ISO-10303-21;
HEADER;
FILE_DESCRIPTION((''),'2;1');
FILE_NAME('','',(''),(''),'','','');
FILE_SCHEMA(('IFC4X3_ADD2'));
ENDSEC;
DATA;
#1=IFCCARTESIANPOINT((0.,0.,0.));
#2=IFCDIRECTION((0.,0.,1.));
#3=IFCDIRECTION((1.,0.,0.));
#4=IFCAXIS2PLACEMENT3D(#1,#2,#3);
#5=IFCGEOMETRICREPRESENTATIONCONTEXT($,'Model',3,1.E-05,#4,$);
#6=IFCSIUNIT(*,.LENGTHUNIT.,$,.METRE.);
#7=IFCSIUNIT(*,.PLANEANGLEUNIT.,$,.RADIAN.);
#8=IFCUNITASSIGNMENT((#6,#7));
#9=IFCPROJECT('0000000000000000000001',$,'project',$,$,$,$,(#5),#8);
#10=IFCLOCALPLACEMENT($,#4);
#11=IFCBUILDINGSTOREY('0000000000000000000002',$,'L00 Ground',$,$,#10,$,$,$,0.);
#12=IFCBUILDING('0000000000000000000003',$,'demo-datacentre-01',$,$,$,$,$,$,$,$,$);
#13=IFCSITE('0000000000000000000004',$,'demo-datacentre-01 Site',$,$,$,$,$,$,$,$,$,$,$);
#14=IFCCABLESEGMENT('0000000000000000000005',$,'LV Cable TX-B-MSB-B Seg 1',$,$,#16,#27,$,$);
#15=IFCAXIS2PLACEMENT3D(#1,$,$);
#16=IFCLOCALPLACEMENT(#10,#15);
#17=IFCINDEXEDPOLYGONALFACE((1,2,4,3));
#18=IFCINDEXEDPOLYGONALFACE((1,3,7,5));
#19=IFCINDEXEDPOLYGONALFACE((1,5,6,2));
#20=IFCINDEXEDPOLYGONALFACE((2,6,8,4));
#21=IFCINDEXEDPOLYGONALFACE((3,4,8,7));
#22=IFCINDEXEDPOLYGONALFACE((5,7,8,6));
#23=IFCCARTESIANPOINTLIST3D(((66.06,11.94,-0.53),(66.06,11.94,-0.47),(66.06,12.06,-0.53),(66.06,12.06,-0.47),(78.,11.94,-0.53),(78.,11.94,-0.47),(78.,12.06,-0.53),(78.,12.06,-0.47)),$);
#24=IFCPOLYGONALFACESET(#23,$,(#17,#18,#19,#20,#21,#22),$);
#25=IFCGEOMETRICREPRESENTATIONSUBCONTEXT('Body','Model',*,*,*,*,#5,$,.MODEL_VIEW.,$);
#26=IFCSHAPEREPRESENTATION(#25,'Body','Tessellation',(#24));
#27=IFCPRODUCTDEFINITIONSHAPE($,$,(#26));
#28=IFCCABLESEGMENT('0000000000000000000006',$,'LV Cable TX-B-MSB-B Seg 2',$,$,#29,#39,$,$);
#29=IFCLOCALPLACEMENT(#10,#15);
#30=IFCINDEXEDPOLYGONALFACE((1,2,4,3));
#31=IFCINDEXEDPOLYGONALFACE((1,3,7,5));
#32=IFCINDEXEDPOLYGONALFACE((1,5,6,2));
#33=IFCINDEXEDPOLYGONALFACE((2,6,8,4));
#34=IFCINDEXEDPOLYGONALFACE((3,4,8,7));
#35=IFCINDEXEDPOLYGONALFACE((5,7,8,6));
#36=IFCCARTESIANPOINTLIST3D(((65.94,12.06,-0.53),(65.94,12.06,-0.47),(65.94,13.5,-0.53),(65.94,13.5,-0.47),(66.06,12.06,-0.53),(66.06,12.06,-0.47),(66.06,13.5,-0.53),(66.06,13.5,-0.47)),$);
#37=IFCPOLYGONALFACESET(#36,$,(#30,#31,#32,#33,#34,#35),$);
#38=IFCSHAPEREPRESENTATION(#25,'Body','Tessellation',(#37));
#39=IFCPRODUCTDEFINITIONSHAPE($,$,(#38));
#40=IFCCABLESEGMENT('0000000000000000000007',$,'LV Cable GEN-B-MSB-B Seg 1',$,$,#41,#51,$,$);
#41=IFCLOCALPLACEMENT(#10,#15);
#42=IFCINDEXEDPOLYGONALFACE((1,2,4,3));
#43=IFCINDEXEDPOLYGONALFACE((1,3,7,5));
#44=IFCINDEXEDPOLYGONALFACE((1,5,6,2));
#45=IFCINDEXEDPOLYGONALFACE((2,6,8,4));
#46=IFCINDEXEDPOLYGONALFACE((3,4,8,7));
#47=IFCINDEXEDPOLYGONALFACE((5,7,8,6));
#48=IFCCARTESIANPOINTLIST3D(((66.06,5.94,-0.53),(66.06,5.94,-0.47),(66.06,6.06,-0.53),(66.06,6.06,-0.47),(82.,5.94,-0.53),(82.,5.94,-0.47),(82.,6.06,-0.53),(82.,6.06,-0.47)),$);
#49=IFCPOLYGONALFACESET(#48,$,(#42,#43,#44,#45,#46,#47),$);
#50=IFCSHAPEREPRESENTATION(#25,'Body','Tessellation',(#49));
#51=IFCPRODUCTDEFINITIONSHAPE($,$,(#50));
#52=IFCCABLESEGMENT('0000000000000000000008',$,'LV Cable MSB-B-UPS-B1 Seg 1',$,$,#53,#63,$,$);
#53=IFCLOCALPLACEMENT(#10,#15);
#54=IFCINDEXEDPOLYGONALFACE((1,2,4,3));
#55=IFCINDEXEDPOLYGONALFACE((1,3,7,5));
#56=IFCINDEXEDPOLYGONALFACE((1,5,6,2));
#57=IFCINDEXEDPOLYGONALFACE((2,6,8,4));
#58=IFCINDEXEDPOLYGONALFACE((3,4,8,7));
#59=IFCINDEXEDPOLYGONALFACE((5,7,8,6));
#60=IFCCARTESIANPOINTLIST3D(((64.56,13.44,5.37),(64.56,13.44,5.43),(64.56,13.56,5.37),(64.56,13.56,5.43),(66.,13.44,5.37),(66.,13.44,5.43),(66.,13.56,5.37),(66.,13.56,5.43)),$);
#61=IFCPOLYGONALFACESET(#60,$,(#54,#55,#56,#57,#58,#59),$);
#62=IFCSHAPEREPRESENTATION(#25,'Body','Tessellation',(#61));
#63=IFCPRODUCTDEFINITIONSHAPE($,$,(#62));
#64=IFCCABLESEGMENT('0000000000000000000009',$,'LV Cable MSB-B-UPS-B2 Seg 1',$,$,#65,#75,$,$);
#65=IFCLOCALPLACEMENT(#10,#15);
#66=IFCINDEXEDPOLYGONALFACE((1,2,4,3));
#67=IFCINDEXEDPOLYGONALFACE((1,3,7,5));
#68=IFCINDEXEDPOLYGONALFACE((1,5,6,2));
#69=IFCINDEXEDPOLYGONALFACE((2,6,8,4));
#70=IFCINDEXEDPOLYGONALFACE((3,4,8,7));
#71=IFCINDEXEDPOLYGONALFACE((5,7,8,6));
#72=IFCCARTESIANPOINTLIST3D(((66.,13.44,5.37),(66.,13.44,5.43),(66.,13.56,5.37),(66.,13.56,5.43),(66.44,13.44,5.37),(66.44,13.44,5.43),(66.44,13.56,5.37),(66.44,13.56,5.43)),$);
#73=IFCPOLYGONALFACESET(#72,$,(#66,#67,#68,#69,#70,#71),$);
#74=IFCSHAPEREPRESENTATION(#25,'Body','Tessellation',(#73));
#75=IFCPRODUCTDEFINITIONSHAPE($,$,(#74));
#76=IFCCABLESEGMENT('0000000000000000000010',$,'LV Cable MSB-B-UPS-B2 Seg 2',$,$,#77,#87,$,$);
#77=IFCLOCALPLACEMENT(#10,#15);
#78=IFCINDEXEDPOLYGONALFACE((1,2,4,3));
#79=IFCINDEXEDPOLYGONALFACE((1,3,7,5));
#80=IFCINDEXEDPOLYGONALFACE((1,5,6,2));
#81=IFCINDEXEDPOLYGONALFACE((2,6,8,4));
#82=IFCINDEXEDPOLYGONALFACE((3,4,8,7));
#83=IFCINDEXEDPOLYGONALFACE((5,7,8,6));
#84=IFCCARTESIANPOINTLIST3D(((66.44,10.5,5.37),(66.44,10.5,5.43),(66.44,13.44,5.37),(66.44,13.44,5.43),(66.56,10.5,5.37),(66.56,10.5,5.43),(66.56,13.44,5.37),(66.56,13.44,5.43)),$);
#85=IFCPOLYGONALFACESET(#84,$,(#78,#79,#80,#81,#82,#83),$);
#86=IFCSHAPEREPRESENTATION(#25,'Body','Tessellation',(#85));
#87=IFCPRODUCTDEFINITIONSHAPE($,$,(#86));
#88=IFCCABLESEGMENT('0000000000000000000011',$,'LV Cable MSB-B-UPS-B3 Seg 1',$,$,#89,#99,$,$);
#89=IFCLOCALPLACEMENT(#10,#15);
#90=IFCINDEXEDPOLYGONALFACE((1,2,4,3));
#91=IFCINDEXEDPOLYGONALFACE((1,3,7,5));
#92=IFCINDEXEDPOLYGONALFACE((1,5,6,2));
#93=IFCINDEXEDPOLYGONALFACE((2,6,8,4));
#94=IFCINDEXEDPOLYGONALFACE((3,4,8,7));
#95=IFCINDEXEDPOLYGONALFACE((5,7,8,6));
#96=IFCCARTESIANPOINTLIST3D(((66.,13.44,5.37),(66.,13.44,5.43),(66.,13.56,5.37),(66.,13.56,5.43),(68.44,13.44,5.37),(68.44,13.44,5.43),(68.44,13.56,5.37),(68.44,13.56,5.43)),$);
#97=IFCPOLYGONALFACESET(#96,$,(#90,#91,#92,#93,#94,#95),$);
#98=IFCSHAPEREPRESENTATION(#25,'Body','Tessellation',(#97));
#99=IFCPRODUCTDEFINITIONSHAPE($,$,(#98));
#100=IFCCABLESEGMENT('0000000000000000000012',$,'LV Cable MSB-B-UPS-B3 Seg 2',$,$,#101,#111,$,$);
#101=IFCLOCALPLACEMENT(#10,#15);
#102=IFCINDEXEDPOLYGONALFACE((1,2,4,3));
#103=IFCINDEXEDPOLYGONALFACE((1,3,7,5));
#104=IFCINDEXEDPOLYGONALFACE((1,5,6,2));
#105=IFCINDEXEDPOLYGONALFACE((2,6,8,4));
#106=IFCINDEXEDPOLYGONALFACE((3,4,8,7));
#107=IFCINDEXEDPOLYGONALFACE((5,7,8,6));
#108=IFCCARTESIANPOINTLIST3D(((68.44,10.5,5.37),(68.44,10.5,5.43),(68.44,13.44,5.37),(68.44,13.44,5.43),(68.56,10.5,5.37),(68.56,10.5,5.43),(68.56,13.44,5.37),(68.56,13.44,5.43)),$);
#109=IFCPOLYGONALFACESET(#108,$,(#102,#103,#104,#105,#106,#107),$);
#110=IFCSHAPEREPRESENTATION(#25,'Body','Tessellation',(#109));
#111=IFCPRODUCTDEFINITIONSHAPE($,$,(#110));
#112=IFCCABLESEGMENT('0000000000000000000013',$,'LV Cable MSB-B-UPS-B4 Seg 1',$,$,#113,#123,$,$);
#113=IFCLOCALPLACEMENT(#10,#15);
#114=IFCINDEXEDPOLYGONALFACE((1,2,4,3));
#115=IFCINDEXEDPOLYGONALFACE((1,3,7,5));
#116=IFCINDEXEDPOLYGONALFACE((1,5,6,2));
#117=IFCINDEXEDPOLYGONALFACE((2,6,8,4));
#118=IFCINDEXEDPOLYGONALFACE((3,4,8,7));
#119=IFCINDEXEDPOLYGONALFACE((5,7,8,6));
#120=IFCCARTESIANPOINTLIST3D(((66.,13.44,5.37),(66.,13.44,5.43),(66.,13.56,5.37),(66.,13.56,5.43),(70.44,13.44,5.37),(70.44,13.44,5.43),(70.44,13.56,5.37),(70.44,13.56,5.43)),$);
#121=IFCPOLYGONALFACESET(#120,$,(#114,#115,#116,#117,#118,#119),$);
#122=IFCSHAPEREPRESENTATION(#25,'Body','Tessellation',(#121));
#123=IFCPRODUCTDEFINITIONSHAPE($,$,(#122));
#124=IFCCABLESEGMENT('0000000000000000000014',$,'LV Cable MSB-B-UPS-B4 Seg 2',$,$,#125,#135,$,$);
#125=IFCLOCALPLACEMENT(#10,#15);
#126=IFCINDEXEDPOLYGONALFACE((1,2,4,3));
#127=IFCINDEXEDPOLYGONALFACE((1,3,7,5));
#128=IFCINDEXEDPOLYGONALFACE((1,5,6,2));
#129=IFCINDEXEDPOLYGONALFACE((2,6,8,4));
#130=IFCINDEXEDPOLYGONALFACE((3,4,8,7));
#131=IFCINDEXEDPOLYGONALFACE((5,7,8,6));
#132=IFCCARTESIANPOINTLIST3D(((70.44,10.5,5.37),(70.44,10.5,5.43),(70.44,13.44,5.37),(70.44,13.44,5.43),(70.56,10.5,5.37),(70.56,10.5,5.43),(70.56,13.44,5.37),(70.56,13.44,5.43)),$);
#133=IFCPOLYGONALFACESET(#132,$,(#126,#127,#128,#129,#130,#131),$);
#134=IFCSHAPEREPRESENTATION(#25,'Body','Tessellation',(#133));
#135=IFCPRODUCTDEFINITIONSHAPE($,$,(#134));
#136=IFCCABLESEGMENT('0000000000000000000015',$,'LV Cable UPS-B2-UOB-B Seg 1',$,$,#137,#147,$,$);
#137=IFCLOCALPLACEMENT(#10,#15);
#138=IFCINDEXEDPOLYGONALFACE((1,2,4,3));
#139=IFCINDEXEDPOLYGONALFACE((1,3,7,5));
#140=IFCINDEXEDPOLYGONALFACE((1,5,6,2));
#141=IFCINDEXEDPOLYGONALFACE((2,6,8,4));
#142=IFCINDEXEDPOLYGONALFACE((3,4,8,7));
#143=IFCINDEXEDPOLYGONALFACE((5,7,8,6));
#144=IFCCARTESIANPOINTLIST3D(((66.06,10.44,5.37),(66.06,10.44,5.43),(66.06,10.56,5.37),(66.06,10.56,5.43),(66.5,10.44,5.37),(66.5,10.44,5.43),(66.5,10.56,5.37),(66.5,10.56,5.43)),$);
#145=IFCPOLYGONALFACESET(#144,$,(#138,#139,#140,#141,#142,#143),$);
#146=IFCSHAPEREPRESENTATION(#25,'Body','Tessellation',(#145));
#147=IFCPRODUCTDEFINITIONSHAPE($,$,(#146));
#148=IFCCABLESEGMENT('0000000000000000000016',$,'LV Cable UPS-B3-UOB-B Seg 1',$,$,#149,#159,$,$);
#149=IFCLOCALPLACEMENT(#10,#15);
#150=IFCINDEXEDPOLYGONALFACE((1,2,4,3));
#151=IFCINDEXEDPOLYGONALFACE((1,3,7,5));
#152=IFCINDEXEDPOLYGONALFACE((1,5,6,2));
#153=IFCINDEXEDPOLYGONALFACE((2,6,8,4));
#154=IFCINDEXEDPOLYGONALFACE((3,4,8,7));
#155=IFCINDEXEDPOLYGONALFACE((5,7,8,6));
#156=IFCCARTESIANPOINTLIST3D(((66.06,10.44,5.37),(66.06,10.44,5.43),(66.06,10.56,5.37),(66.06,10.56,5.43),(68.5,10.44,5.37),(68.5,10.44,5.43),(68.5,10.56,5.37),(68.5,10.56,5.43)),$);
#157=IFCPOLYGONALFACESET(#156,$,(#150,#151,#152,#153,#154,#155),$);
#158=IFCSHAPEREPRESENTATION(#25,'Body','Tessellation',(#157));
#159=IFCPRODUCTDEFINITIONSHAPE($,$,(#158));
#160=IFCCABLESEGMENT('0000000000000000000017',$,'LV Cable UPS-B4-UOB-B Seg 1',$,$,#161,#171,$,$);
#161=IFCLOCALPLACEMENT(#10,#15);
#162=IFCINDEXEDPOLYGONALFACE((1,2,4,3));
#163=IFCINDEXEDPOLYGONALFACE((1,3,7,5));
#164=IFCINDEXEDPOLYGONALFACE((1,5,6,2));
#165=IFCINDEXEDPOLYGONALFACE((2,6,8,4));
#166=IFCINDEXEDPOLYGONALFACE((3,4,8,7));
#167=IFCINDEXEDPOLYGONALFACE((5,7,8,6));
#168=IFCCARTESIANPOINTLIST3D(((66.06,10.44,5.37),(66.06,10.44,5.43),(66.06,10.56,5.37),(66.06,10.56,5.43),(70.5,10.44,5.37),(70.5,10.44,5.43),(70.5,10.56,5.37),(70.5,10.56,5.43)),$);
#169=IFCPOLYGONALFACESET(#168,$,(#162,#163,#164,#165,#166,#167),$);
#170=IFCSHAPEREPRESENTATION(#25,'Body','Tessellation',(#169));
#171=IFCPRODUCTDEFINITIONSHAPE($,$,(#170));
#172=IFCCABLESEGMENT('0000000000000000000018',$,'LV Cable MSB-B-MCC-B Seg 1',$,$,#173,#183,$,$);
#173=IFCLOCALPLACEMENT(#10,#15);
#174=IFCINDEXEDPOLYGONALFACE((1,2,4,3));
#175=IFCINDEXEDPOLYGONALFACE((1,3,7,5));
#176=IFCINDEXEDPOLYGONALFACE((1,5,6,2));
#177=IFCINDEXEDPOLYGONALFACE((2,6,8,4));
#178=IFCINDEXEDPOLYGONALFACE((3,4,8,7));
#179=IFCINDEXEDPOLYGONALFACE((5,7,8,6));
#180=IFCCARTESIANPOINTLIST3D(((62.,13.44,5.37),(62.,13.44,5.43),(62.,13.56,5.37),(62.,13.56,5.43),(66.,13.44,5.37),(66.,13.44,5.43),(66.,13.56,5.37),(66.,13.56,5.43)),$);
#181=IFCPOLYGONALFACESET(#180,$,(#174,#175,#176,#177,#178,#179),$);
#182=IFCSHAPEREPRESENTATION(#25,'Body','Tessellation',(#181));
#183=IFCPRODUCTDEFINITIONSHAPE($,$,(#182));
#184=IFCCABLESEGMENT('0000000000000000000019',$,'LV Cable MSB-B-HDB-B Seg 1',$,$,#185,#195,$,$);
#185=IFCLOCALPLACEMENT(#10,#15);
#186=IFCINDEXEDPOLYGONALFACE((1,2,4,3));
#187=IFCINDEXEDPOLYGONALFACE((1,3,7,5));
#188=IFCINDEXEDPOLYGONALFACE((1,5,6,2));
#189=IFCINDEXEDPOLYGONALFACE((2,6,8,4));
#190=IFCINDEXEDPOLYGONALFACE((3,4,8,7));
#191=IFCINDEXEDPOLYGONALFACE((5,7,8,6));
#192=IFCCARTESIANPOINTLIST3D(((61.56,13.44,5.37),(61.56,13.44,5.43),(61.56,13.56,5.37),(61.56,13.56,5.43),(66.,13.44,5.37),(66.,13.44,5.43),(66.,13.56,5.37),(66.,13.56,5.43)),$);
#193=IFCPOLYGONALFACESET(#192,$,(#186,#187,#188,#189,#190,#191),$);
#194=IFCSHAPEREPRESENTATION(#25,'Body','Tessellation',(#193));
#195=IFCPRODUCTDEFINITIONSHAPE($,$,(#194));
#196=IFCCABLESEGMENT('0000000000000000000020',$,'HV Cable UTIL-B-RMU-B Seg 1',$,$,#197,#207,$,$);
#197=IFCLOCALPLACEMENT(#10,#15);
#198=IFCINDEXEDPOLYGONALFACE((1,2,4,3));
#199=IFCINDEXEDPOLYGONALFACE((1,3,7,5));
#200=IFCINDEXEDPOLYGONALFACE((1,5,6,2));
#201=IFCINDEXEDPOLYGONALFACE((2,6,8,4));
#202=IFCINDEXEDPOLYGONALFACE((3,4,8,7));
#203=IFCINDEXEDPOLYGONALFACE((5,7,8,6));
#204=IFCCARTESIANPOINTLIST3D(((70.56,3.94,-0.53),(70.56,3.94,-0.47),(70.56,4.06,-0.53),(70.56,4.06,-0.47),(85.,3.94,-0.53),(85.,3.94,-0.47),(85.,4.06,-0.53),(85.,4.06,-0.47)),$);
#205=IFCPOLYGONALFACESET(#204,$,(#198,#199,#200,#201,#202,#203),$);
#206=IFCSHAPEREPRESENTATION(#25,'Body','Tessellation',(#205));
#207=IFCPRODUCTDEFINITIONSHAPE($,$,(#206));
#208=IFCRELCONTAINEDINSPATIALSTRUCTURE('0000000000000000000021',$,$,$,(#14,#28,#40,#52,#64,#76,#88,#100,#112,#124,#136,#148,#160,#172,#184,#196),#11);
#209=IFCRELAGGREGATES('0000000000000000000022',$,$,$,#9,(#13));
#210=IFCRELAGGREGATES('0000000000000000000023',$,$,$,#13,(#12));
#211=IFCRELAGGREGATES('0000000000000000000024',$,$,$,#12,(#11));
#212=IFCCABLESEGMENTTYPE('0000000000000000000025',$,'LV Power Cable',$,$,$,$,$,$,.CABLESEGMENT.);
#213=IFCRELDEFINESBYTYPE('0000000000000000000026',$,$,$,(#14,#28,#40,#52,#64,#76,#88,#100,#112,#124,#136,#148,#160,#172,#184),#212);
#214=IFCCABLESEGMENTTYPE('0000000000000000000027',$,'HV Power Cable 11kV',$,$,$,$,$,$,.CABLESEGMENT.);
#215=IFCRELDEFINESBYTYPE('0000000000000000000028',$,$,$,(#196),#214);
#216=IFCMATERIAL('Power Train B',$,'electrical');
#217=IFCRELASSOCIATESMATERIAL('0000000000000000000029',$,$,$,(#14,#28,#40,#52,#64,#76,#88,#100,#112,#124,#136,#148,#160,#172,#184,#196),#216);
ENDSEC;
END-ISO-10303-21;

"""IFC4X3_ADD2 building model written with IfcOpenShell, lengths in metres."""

from ifc_helpers import new_model, si_unit, frame, origin_with_axes, place, context, subcontext, project, spatial, rectangle, extrude, material, type_object, element, save


model = new_model("IFC4X3_ADD2")

# Units and contexts
model_context = context("Model", 3, precision=1e-05, world=origin_with_axes())
body_context = subcontext(model_context, "Body", "Model", "MODEL_VIEW")
ifc_project = project(units=[si_unit("LENGTHUNIT", "METRE"), si_unit("PLANEANGLEUNIT", "RADIAN")], contexts=[model_context])

# Site, building, storey
site = spatial("IfcSite", under=ifc_project, Name="demo-datacentre-01 Site")
building = spatial("IfcBuilding", under=site, Name="demo-datacentre-01")
storey_placement = place(None, origin_with_axes())
storey = spatial("IfcBuildingStorey", under=building, at=storey_placement, Name="L00 Ground", Elevation=0.0)

# Shared definitions
ifc_material = material(Name="Power Train B", Category="electrical")

# Cable segments
cable_segment_type_1 = type_object("IfcCableSegmentType", Name="LV Power Cable", PredefinedType="CABLESEGMENT")
cable_segment_1_placement = place(storey_placement, frame((78.0, 12.0, -0.5), z_axis=(-1.0, 0.0, 0.0), x_axis=(0.0, -1.0, 0.0)))
element("IfcCableSegment", 1, at=cable_segment_1_placement, inside=storey, type_object=cable_segment_type_1, material=ifc_material, Name="LV Cable TX-B-MSB-B Seg 1", context=body_context, shape_type="SweptSolid", body=[
    extrude(rectangle(XDim=0.12, YDim=0.06), origin_with_axes(), (0.0, 0.0, 1.0), 11.94),
])
cable_segment_2_placement = place(storey_placement, frame((66.0, 12.06, -0.5), z_axis=(0.0, 1.0, 0.0), x_axis=(-1.0, 0.0, 0.0)))
element("IfcCableSegment", 2, at=cable_segment_2_placement, inside=storey, type_object=cable_segment_type_1, material=ifc_material, Name="LV Cable TX-B-MSB-B Seg 2", context=body_context, shape_type="SweptSolid", body=[
    extrude(rectangle(XDim=0.12, YDim=0.06), origin_with_axes(), (0.0, 0.0, 1.0), 1.44),
])
cable_segment_3_placement = place(storey_placement, frame((82.0, 6.0, -0.5), z_axis=(-1.0, 0.0, 0.0), x_axis=(0.0, -1.0, 0.0)))
element("IfcCableSegment", 3, at=cable_segment_3_placement, inside=storey, type_object=cable_segment_type_1, material=ifc_material, Name="LV Cable GEN-B-MSB-B Seg 1", context=body_context, shape_type="SweptSolid", body=[
    extrude(rectangle(XDim=0.12, YDim=0.06), origin_with_axes(), (0.0, 0.0, 1.0), 15.94),
])
cable_segment_4_placement = place(storey_placement, frame((66.0, 13.5, 5.4), z_axis=(-1.0, 0.0, 0.0), x_axis=(0.0, -1.0, 0.0)))
element("IfcCableSegment", 4, at=cable_segment_4_placement, inside=storey, type_object=cable_segment_type_1, material=ifc_material, Name="LV Cable MSB-B-UPS-B1 Seg 1", context=body_context, shape_type="SweptSolid", body=[
    extrude(rectangle(XDim=0.12, YDim=0.06), origin_with_axes(), (0.0, 0.0, 1.0), 1.44),
])
cable_segment_5_placement = place(storey_placement, frame((66.0, 13.5, 5.4), z_axis=(1.0, 0.0, 0.0), x_axis=(0.0, 1.0, 0.0)))
element("IfcCableSegment", 5, at=cable_segment_5_placement, inside=storey, type_object=cable_segment_type_1, material=ifc_material, Name="LV Cable MSB-B-UPS-B2 Seg 1", context=body_context, shape_type="SweptSolid", body=[
    extrude(rectangle(XDim=0.12, YDim=0.06), origin_with_axes(), (0.0, 0.0, 1.0), 0.44),
])
cable_segment_6_placement = place(storey_placement, frame((66.5, 13.44, 5.4), z_axis=(0.0, -1.0, 0.0), x_axis=(1.0, 0.0, 0.0)))
element("IfcCableSegment", 6, at=cable_segment_6_placement, inside=storey, type_object=cable_segment_type_1, material=ifc_material, Name="LV Cable MSB-B-UPS-B2 Seg 2", context=body_context, shape_type="SweptSolid", body=[
    extrude(rectangle(XDim=0.12, YDim=0.06), origin_with_axes(), (0.0, 0.0, 1.0), 2.94),
])
cable_segment_7_placement = place(storey_placement, frame((66.0, 13.5, 5.4), z_axis=(1.0, 0.0, 0.0), x_axis=(0.0, 1.0, 0.0)))
element("IfcCableSegment", 7, at=cable_segment_7_placement, inside=storey, type_object=cable_segment_type_1, material=ifc_material, Name="LV Cable MSB-B-UPS-B3 Seg 1", context=body_context, shape_type="SweptSolid", body=[
    extrude(rectangle(XDim=0.12, YDim=0.06), origin_with_axes(), (0.0, 0.0, 1.0), 2.44),
])
cable_segment_8_placement = place(storey_placement, frame((68.5, 13.44, 5.4), z_axis=(0.0, -1.0, 0.0), x_axis=(1.0, 0.0, 0.0)))
element("IfcCableSegment", 8, at=cable_segment_8_placement, inside=storey, type_object=cable_segment_type_1, material=ifc_material, Name="LV Cable MSB-B-UPS-B3 Seg 2", context=body_context, shape_type="SweptSolid", body=[
    extrude(rectangle(XDim=0.12, YDim=0.06), origin_with_axes(), (0.0, 0.0, 1.0), 2.94),
])
cable_segment_9_placement = place(storey_placement, frame((66.0, 13.5, 5.4), z_axis=(1.0, 0.0, 0.0), x_axis=(0.0, 1.0, 0.0)))
element("IfcCableSegment", 9, at=cable_segment_9_placement, inside=storey, type_object=cable_segment_type_1, material=ifc_material, Name="LV Cable MSB-B-UPS-B4 Seg 1", context=body_context, shape_type="SweptSolid", body=[
    extrude(rectangle(XDim=0.12, YDim=0.06), origin_with_axes(), (0.0, 0.0, 1.0), 4.44),
])
cable_segment_10_placement = place(storey_placement, frame((70.5, 13.44, 5.4), z_axis=(0.0, -1.0, 0.0), x_axis=(1.0, 0.0, 0.0)))
element("IfcCableSegment", 10, at=cable_segment_10_placement, inside=storey, type_object=cable_segment_type_1, material=ifc_material, Name="LV Cable MSB-B-UPS-B4 Seg 2", context=body_context, shape_type="SweptSolid", body=[
    extrude(rectangle(XDim=0.12, YDim=0.06), origin_with_axes(), (0.0, 0.0, 1.0), 2.94),
])
cable_segment_11_placement = place(storey_placement, frame((66.5, 10.5, 5.4), z_axis=(-1.0, 0.0, 0.0), x_axis=(0.0, -1.0, 0.0)))
element("IfcCableSegment", 11, at=cable_segment_11_placement, inside=storey, type_object=cable_segment_type_1, material=ifc_material, Name="LV Cable UPS-B2-UOB-B Seg 1", context=body_context, shape_type="SweptSolid", body=[
    extrude(rectangle(XDim=0.12, YDim=0.06), origin_with_axes(), (0.0, 0.0, 1.0), 0.44),
])
cable_segment_12_placement = place(storey_placement, frame((68.5, 10.5, 5.4), z_axis=(-1.0, 0.0, 0.0), x_axis=(0.0, -1.0, 0.0)))
element("IfcCableSegment", 12, at=cable_segment_12_placement, inside=storey, type_object=cable_segment_type_1, material=ifc_material, Name="LV Cable UPS-B3-UOB-B Seg 1", context=body_context, shape_type="SweptSolid", body=[
    extrude(rectangle(XDim=0.12, YDim=0.06), origin_with_axes(), (0.0, 0.0, 1.0), 2.44),
])
cable_segment_13_placement = place(storey_placement, frame((70.5, 10.5, 5.4), z_axis=(-1.0, 0.0, 0.0), x_axis=(0.0, -1.0, 0.0)))
element("IfcCableSegment", 13, at=cable_segment_13_placement, inside=storey, type_object=cable_segment_type_1, material=ifc_material, Name="LV Cable UPS-B4-UOB-B Seg 1", context=body_context, shape_type="SweptSolid", body=[
    extrude(rectangle(XDim=0.12, YDim=0.06), origin_with_axes(), (0.0, 0.0, 1.0), 4.44),
])
cable_segment_14_placement = place(storey_placement, frame((66.0, 13.5, 5.4), z_axis=(-1.0, 0.0, 0.0), x_axis=(0.0, -1.0, 0.0)))
element("IfcCableSegment", 14, at=cable_segment_14_placement, inside=storey, type_object=cable_segment_type_1, material=ifc_material, Name="LV Cable MSB-B-MCC-B Seg 1", context=body_context, shape_type="SweptSolid", body=[
    extrude(rectangle(XDim=0.12, YDim=0.06), origin_with_axes(), (0.0, 0.0, 1.0), 4.0),
])
cable_segment_15_placement = place(storey_placement, frame((66.0, 13.5, 5.4), z_axis=(-1.0, 0.0, 0.0), x_axis=(0.0, -1.0, 0.0)))
element("IfcCableSegment", 15, at=cable_segment_15_placement, inside=storey, type_object=cable_segment_type_1, material=ifc_material, Name="LV Cable MSB-B-HDB-B Seg 1", context=body_context, shape_type="SweptSolid", body=[
    extrude(rectangle(XDim=0.12, YDim=0.06), origin_with_axes(), (0.0, 0.0, 1.0), 4.44),
])
cable_segment_type_2 = type_object("IfcCableSegmentType", Name="HV Power Cable 11kV", PredefinedType="CABLESEGMENT")
cable_segment_16_placement = place(storey_placement, frame((85.0, 4.0, -0.5), z_axis=(-1.0, 0.0, 0.0), x_axis=(0.0, -1.0, 0.0)))
element("IfcCableSegment", 16, at=cable_segment_16_placement, inside=storey, type_object=cable_segment_type_2, material=ifc_material, Name="HV Cable UTIL-B-RMU-B Seg 1", context=body_context, shape_type="SweptSolid", body=[
    extrude(rectangle(XDim=0.12, YDim=0.06), origin_with_axes(), (0.0, 0.0, 1.0), 14.44),
])

save(model, "model.ifc")
